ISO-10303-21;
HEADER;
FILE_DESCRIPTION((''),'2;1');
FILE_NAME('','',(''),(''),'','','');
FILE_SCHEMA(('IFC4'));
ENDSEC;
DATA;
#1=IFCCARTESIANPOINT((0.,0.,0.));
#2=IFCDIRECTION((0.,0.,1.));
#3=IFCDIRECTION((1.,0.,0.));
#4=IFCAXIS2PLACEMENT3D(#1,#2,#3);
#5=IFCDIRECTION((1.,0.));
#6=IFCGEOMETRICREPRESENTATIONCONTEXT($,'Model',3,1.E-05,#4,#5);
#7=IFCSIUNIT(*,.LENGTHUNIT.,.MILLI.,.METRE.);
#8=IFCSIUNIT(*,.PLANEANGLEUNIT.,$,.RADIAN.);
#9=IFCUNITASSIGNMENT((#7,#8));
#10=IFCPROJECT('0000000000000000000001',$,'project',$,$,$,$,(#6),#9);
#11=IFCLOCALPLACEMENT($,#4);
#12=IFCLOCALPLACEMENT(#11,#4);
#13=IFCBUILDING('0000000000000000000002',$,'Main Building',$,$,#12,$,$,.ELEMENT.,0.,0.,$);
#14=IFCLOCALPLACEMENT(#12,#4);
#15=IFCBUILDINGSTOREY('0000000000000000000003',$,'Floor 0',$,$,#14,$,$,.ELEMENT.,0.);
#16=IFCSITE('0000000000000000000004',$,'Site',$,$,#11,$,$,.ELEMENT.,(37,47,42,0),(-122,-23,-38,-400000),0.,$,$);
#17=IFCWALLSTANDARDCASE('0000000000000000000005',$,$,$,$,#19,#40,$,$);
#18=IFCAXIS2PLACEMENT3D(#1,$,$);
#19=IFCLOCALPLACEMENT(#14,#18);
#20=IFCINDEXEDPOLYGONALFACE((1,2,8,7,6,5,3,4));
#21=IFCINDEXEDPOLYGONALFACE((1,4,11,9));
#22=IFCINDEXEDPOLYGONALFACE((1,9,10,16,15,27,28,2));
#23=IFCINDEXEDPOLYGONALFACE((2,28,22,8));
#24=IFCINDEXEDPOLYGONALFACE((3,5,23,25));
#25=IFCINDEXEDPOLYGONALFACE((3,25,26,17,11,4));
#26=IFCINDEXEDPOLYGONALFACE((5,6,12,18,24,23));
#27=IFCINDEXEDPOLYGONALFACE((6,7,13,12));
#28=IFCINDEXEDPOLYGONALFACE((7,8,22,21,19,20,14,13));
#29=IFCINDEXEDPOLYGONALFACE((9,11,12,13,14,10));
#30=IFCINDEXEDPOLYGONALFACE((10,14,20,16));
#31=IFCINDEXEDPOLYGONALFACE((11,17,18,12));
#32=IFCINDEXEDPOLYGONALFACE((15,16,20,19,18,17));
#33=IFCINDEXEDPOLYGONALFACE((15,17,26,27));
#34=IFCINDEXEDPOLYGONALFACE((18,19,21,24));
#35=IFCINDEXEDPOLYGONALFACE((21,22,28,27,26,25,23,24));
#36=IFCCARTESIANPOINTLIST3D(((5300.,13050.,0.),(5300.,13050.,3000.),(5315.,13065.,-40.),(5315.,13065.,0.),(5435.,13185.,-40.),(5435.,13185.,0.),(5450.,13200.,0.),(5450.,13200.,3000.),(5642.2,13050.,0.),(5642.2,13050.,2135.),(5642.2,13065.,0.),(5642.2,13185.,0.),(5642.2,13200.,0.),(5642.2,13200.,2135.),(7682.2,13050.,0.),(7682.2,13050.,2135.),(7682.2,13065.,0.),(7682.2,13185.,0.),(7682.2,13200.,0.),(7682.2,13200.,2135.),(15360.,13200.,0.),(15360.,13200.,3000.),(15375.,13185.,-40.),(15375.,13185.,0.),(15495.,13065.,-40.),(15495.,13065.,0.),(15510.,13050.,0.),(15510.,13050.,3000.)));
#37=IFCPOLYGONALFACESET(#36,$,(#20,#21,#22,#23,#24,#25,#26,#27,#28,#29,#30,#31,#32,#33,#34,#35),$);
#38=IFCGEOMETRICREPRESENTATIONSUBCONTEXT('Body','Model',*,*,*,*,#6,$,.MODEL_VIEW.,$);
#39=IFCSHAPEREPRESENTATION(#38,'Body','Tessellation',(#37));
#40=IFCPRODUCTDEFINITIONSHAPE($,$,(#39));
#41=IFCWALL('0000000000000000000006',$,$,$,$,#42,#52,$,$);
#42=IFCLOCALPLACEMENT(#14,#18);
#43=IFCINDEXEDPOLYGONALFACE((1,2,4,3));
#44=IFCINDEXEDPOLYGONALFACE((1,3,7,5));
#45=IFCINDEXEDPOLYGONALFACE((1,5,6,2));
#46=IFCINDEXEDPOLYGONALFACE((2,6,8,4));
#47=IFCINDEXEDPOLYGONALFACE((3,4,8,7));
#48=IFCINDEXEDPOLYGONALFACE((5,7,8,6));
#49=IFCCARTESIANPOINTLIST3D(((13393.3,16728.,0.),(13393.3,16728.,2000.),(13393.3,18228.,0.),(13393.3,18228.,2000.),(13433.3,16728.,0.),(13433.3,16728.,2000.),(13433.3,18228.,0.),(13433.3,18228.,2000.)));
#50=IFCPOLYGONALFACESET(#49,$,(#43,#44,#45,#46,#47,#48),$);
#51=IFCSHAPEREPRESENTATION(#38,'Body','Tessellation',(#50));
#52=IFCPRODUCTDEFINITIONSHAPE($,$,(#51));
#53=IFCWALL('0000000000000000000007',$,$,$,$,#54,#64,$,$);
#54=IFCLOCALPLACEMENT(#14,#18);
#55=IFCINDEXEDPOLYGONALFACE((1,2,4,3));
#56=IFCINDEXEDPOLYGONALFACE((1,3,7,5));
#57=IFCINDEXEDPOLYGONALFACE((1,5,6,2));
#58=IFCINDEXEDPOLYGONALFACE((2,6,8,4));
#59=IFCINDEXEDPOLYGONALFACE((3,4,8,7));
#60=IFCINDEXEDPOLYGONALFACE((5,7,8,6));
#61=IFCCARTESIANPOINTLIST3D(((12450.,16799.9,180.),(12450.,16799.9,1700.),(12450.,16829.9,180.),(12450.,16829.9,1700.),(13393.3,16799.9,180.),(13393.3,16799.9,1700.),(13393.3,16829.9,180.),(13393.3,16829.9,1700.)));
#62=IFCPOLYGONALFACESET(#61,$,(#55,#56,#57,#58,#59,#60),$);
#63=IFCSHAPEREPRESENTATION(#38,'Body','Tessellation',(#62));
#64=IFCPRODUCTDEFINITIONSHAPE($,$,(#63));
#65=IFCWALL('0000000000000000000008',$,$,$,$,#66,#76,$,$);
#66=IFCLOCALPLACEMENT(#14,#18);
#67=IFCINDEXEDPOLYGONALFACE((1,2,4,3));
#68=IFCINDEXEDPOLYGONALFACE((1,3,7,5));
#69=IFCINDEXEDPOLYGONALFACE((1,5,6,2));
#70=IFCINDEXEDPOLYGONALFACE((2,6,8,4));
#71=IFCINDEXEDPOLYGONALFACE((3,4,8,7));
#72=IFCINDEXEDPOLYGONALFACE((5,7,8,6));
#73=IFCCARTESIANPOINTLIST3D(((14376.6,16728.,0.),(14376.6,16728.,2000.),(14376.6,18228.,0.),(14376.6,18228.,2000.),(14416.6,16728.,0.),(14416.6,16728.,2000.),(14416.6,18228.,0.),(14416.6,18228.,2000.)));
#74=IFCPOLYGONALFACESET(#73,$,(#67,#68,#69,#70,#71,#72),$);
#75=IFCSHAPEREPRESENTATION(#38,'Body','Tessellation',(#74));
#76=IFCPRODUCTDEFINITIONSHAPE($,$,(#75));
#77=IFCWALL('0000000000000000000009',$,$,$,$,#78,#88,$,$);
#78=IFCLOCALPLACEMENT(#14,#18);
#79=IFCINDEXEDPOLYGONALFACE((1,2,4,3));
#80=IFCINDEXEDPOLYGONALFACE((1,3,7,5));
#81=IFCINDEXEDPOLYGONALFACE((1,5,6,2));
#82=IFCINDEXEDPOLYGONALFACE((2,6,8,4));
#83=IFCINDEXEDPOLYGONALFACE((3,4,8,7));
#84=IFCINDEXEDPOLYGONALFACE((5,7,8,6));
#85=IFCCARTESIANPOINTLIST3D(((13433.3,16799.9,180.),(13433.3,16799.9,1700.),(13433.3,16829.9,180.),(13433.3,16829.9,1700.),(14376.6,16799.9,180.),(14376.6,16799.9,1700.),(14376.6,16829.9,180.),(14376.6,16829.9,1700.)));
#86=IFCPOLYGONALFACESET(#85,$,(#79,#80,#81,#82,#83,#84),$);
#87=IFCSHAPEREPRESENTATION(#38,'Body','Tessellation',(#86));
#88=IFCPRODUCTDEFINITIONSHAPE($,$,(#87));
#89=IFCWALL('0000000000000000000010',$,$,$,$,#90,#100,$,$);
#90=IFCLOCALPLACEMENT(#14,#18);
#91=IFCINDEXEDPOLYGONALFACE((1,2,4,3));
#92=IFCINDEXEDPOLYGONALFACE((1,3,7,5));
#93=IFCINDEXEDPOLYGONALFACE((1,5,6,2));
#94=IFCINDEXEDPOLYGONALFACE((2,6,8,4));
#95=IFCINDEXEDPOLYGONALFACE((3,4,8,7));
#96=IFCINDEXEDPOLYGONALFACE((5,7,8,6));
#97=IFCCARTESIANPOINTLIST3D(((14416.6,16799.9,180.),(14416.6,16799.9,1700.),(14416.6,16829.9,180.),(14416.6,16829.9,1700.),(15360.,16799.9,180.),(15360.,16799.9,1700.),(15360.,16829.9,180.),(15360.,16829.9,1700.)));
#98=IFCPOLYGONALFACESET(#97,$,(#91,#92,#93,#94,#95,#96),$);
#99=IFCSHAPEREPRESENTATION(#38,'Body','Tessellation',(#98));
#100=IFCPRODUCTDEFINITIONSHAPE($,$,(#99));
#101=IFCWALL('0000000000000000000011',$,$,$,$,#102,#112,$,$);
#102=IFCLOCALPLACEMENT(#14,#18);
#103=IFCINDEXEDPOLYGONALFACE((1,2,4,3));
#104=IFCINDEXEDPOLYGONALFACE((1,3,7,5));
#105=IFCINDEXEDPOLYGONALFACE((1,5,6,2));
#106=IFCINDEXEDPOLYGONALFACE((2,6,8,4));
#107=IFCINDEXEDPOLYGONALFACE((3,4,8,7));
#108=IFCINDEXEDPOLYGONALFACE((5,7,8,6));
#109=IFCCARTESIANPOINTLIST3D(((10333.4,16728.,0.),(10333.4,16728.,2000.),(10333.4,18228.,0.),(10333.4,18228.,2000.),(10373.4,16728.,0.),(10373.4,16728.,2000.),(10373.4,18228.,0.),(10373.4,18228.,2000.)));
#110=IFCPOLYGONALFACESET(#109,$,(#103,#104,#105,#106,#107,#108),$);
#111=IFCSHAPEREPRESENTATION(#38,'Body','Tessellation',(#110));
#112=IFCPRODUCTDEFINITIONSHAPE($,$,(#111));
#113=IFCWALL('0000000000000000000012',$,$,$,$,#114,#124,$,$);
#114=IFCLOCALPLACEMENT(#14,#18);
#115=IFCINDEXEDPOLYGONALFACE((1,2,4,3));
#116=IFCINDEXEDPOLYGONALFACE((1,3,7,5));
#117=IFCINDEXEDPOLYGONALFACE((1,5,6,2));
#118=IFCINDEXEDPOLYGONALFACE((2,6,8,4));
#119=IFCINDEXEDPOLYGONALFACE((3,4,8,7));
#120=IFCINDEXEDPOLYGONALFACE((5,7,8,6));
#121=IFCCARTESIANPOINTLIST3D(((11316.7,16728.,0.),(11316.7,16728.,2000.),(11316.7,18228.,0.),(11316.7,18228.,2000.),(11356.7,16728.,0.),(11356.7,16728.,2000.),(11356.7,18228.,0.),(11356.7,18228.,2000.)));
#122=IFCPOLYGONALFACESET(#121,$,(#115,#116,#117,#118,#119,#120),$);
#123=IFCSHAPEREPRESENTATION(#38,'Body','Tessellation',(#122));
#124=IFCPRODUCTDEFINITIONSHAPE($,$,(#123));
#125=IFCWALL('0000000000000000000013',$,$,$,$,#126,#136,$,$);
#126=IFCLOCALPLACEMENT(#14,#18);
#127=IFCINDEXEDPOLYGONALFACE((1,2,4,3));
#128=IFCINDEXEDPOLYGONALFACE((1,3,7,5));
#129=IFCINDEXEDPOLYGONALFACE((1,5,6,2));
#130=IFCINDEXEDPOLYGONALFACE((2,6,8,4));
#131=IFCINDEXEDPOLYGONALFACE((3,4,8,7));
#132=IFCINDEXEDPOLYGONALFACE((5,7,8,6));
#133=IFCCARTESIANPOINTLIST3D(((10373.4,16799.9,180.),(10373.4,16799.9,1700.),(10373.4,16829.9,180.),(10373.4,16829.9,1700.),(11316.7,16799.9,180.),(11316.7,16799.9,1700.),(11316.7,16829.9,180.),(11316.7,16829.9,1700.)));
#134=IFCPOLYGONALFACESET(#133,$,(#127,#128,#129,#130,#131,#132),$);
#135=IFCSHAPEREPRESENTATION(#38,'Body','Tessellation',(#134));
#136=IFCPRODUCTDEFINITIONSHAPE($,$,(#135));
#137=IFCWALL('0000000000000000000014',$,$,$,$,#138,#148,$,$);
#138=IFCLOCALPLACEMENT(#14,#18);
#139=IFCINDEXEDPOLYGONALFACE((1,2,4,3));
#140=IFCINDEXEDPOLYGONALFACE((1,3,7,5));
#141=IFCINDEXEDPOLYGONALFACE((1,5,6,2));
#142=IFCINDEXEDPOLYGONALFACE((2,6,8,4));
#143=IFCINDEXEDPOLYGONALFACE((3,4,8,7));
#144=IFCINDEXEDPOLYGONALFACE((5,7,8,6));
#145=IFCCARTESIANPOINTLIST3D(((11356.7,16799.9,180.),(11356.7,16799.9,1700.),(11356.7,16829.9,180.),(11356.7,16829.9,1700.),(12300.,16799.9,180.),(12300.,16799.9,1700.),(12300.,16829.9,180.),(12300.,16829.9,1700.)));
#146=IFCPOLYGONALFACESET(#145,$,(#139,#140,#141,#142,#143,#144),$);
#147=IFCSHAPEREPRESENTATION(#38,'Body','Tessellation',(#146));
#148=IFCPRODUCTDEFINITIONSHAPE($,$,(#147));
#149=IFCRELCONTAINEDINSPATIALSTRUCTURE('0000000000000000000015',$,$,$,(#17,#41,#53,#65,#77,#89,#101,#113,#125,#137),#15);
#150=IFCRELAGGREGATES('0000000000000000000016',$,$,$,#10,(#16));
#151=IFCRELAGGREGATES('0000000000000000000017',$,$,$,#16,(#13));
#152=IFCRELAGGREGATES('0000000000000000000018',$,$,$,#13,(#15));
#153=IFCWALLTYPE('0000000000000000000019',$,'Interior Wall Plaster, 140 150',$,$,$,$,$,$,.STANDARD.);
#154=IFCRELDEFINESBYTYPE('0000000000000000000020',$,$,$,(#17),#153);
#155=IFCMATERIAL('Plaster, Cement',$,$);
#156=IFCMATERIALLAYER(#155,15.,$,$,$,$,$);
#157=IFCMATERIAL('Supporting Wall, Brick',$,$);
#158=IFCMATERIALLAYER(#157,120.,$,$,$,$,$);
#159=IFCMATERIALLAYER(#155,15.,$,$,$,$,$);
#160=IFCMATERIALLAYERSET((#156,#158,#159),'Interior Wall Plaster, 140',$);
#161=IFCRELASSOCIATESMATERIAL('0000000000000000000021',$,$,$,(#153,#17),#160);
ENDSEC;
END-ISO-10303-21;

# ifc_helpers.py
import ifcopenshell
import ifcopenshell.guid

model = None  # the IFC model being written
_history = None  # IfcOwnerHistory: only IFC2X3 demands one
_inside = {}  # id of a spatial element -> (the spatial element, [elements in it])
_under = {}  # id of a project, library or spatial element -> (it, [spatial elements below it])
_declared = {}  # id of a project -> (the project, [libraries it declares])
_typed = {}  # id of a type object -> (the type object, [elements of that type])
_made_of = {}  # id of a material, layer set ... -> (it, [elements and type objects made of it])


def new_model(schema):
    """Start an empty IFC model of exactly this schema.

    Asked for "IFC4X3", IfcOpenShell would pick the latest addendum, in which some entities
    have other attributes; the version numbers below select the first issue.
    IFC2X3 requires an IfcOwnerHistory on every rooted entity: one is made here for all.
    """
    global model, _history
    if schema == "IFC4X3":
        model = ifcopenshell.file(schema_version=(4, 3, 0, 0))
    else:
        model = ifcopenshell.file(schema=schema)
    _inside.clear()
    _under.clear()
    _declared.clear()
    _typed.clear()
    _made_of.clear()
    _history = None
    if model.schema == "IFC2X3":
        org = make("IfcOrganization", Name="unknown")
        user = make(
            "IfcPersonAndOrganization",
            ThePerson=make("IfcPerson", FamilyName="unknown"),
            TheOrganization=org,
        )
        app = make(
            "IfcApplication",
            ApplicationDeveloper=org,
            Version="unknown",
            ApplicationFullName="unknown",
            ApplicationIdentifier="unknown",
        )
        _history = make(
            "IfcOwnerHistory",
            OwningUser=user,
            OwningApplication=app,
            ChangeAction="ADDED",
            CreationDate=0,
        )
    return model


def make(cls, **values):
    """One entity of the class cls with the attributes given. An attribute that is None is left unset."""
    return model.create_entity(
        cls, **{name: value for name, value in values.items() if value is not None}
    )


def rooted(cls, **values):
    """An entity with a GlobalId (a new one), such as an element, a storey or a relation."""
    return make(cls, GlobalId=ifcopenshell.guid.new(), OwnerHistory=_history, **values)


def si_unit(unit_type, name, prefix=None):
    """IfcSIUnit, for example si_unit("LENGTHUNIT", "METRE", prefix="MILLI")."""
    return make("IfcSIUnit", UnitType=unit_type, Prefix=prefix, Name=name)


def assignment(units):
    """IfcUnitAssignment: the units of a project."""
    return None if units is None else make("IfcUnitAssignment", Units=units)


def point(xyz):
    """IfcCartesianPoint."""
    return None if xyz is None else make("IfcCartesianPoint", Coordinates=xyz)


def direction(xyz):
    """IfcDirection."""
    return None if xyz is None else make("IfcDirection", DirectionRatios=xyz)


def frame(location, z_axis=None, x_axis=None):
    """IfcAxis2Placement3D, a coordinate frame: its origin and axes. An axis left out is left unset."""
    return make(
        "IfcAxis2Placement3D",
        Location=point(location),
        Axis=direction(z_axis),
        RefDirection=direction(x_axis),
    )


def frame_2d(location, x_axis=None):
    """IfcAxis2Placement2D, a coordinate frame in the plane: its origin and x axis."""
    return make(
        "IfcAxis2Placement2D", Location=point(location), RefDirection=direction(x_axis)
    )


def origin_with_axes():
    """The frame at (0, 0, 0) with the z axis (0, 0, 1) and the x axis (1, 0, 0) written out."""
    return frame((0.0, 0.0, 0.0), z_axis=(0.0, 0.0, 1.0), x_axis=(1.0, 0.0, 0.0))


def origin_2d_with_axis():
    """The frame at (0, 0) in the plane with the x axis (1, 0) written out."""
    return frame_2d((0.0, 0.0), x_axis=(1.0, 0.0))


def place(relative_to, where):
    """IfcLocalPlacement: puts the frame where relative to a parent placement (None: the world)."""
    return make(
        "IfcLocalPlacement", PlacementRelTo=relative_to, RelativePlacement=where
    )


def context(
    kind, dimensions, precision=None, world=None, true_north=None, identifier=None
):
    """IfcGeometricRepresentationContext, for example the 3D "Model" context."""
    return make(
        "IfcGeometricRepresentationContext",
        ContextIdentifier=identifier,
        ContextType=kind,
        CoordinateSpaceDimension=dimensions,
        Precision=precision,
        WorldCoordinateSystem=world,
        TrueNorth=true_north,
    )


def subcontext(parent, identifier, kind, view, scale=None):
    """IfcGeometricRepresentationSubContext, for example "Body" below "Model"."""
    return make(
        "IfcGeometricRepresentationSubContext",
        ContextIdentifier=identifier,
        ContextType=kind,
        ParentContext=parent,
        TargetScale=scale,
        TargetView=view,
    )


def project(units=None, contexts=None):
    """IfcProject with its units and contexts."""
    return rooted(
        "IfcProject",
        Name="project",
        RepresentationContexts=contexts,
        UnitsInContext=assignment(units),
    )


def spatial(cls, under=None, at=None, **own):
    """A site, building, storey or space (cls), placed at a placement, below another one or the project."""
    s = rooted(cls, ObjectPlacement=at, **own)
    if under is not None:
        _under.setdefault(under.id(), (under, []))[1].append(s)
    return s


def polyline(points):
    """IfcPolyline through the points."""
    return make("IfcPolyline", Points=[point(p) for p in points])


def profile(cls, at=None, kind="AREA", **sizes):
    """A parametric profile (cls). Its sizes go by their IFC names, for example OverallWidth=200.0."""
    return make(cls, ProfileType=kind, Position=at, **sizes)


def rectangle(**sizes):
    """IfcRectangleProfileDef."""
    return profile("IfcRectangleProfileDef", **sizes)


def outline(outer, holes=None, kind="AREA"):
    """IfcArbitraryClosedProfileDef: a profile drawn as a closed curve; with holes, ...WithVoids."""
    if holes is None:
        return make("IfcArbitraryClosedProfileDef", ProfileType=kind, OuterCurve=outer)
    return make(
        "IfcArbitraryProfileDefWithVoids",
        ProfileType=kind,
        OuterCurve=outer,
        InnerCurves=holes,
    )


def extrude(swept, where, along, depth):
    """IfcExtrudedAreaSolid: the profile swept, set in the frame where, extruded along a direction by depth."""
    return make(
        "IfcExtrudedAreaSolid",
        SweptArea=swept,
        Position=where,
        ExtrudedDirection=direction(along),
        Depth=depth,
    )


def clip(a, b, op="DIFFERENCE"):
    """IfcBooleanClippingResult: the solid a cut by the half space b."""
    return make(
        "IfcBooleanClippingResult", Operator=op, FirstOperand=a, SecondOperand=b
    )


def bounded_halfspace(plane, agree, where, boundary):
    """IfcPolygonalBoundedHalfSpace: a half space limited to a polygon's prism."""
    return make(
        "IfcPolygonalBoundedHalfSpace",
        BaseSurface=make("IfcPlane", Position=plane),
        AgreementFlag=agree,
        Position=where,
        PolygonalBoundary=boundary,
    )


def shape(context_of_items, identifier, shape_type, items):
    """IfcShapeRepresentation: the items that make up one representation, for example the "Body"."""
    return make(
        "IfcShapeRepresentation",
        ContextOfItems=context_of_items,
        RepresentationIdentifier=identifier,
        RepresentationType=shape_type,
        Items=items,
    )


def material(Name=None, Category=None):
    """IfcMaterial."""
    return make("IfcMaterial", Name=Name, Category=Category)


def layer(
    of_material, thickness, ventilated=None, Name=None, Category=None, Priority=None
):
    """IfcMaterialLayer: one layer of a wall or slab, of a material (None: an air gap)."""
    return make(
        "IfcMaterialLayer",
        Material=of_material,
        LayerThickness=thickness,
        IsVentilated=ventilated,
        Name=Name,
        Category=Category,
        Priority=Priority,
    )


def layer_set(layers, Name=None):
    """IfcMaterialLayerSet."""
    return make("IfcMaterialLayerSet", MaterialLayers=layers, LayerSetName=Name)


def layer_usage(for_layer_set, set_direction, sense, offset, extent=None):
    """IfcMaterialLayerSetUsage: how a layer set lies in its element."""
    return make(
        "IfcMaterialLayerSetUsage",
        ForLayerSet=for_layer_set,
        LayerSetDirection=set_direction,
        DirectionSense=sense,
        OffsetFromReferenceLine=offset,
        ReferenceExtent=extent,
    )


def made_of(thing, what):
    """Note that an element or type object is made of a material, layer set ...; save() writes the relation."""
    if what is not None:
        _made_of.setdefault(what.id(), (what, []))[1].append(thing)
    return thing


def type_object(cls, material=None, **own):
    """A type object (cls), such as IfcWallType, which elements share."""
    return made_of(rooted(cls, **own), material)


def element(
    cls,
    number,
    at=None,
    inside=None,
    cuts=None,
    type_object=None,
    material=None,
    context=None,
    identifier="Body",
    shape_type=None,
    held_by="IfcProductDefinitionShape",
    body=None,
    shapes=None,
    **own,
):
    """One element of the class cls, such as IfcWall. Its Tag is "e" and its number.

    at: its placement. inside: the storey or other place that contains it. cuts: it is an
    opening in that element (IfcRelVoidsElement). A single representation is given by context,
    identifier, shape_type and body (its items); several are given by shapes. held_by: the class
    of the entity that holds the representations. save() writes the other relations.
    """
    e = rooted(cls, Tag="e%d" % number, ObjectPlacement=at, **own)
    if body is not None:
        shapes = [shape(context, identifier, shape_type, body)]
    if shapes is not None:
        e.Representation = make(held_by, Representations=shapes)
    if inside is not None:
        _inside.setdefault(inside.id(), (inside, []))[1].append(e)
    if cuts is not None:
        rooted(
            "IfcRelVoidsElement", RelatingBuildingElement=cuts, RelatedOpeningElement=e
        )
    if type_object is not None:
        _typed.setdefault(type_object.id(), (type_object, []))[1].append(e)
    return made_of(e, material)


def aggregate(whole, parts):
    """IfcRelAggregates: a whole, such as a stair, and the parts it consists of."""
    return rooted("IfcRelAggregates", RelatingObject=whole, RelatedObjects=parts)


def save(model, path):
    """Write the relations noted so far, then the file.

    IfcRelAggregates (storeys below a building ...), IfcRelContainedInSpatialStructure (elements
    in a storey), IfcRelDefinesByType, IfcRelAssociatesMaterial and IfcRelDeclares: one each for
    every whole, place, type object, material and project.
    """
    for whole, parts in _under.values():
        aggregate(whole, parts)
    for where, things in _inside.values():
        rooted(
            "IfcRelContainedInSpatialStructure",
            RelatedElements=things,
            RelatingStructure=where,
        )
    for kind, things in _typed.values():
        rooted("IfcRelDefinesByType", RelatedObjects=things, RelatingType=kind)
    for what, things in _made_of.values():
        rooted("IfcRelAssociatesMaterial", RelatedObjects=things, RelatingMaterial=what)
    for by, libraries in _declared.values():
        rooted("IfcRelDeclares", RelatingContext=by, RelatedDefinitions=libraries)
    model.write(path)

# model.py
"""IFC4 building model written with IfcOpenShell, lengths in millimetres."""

from ifc_helpers import new_model, si_unit, direction, frame, frame_2d, origin_with_axes, origin_2d_with_axis, place, context, subcontext, project, spatial, polyline, rectangle, outline, extrude, clip, bounded_halfspace, material, layer, layer_set, layer_usage, type_object, element, save


model = new_model("IFC4")

# Units and contexts
model_context = context("Model", 3, precision=1e-05, world=origin_with_axes(), true_north=direction((1.0, 0.0)))
body_context = subcontext(model_context, "Body", "Model", "MODEL_VIEW")
ifc_project = project(units=[si_unit("LENGTHUNIT", "METRE", prefix="MILLI"), si_unit("PLANEANGLEUNIT", "RADIAN")], contexts=[model_context])

# Site, building, storey
site_placement = place(None, origin_with_axes())
site = spatial("IfcSite", under=ifc_project, at=site_placement, Name="Site", CompositionType="ELEMENT", RefLatitude=(37, 47, 42, 0), RefLongitude=(-122, -23, -38, -400000), RefElevation=0.0)
building_placement = place(site_placement, origin_with_axes())
building = spatial("IfcBuilding", under=site, at=building_placement, Name="Main Building", CompositionType="ELEMENT", ElevationOfRefHeight=0.0, ElevationOfTerrain=0.0)
storey_placement = place(building_placement, origin_with_axes())
storey = spatial("IfcBuildingStorey", under=building, at=storey_placement, Name="Floor 0", CompositionType="ELEMENT", Elevation=0.0)

# Shared definitions
ifc_material_1 = material(Name="Supporting Wall, Brick")

# Shared definitions
ifc_material_2 = material(Name="Plaster, Cement")
ifc_layer_1 = layer(ifc_material_2, 15.0)
ifc_layer_2 = layer(ifc_material_1, 120.0)
ifc_layer_3 = layer(ifc_material_2, 15.0)
ifc_layer_set_1 = layer_set([ifc_layer_1, ifc_layer_2, ifc_layer_3], Name="Interior Wall Plaster, 140")
wall_type_1 = type_object("IfcWallType", Name="Interior Wall Plaster, 140 150", PredefinedType="STANDARD", material=ifc_layer_set_1)

# Wall, opening
ifc_layer_usage_1 = layer_usage(ifc_layer_set_1, "AXIS2", "POSITIVE", 0.0)
wall_1_placement = place(storey_placement, frame((5300.0, 13050.0, -40.0), z_axis=(0.0, 0.0, 1.0), x_axis=(1.0, 0.0, 0.0)))
wall_1 = element("IfcWallStandardCase", 1, at=wall_1_placement, inside=storey, type_object=wall_type_1, material=ifc_layer_usage_1, context=body_context, shape_type="Clipping", body=[
    clip(clip(extrude(outline(polyline([(-4955.0, 75.0), (4955.0, 75.0), (5105.0, -75.0), (-5105.0, -75.0), (-4955.0, 75.0)])), frame((5105.0, 75.0, 0.0), z_axis=(0.0, 0.0, 1.0), x_axis=(1.0, 0.0, 0.0)), (0.0, 0.0, 1.0), 3040.0), bounded_halfspace(frame((-5300.0, -13050.0, 40.0), z_axis=(0.0, 0.0, -1.0), x_axis=(-1.0, 0.0, 0.0)), False, frame((5105.0, 75.0, 0.0), z_axis=(0.0, 0.0, 1.0), x_axis=(1.0, 0.0, 0.0)), polyline([(-4955.0, 75.0), (4955.0, 75.0), (4970.0, 60.0), (-4970.0, 60.0), (-4955.0, 75.0)]))), bounded_halfspace(frame((-5300.0, -13050.0, 40.0), z_axis=(0.0, 0.0, -1.0), x_axis=(-1.0, 0.0, 0.0)), False, frame((5105.0, 75.0, 0.0), z_axis=(0.0, 0.0, 1.0), x_axis=(1.0, 0.0, 0.0)), polyline([(-5090.0, -60.0), (5090.0, -60.0), (5105.0, -75.0), (-5105.0, -75.0), (-5090.0, -60.0)]))),
])
opening_1_placement = place(wall_1_placement, frame((2382.2, 150.0, 40.0), z_axis=(0.0, 0.0, 1.0), x_axis=(-1.0, 0.0, 0.0)))
element("IfcOpeningElement", 2, at=opening_1_placement, cuts=wall_1, ObjectType="Opening", context=body_context, shape_type="SweptSolid", body=[
    extrude(outline(polyline([(-1020.0, -1067.5), (-1020.0, 1067.5), (1020.0, 1067.5), (1020.0, -1067.5), (-1020.0, -1067.5)])), frame((1020.0, 0.0, 1067.5), z_axis=(0.0, 1.0, 0.0), x_axis=(1.0, 0.0, 0.0)), (0.0, 0.0, 1.0), 1000.0),
])

# Walls
wall_2_placement = place(storey_placement, origin_with_axes())
element("IfcWall", 3, at=wall_2_placement, inside=storey, context=body_context, shape_type="SweptSolid", body=[
    extrude(rectangle(XDim=1500.0, YDim=40.0, at=frame_2d((0.0, 0.0), x_axis=(0.0, 1.0))), frame((13413.3, 17478.0, 0.0), z_axis=(0.0, 0.0, 1.0), x_axis=(1.0, 0.0, 0.0)), (0.0, 0.0, 1.0), 2000.0),
])
wall_3_placement = place(storey_placement, origin_with_axes())
element("IfcWall", 4, at=wall_3_placement, inside=storey, context=body_context, shape_type="SweptSolid", body=[
    extrude(rectangle(XDim=943.3, YDim=30.0, at=origin_2d_with_axis()), frame((12921.7, 16814.9, 180.0), z_axis=(0.0, 0.0, 1.0), x_axis=(1.0, 0.0, 0.0)), (0.0, 0.0, 1.0), 1520.0),
])
wall_4_placement = place(storey_placement, origin_with_axes())
element("IfcWall", 5, at=wall_4_placement, inside=storey, context=body_context, shape_type="SweptSolid", body=[
    extrude(rectangle(XDim=1500.0, YDim=40.0, at=frame_2d((0.0, 0.0), x_axis=(0.0, 1.0))), frame((14396.6, 17478.0, 0.0), z_axis=(0.0, 0.0, 1.0), x_axis=(1.0, 0.0, 0.0)), (0.0, 0.0, 1.0), 2000.0),
])
wall_5_placement = place(storey_placement, origin_with_axes())
element("IfcWall", 6, at=wall_5_placement, inside=storey, context=body_context, shape_type="SweptSolid", body=[
    extrude(rectangle(XDim=943.3, YDim=30.0, at=origin_2d_with_axis()), frame((13905.0, 16814.9, 180.0), z_axis=(0.0, 0.0, 1.0), x_axis=(1.0, 0.0, 0.0)), (0.0, 0.0, 1.0), 1520.0),
])
wall_6_placement = place(storey_placement, origin_with_axes())
element("IfcWall", 7, at=wall_6_placement, inside=storey, context=body_context, shape_type="SweptSolid", body=[
    extrude(rectangle(XDim=943.3, YDim=30.0, at=origin_2d_with_axis()), frame((14888.3, 16814.9, 180.0), z_axis=(0.0, 0.0, 1.0), x_axis=(1.0, 0.0, 0.0)), (0.0, 0.0, 1.0), 1520.0),
])
wall_7_placement = place(storey_placement, origin_with_axes())
element("IfcWall", 8, at=wall_7_placement, inside=storey, context=body_context, shape_type="SweptSolid", body=[
    extrude(rectangle(XDim=1500.0, YDim=40.0, at=frame_2d((0.0, 0.0), x_axis=(0.0, 1.0))), frame((10353.4, 17478.0, 0.0), z_axis=(0.0, 0.0, 1.0), x_axis=(1.0, 0.0, 0.0)), (0.0, 0.0, 1.0), 2000.0),
])
wall_8_placement = place(storey_placement, origin_with_axes())
element("IfcWall", 9, at=wall_8_placement, inside=storey, context=body_context, shape_type="SweptSolid", body=[
    extrude(rectangle(XDim=1500.0, YDim=40.0, at=frame_2d((0.0, 0.0), x_axis=(0.0, 1.0))), frame((11336.7, 17478.0, 0.0), z_axis=(0.0, 0.0, 1.0), x_axis=(1.0, 0.0, 0.0)), (0.0, 0.0, 1.0), 2000.0),
])
wall_9_placement = place(storey_placement, origin_with_axes())
element("IfcWall", 10, at=wall_9_placement, inside=storey, context=body_context, shape_type="SweptSolid", body=[
    extrude(rectangle(XDim=943.3, YDim=30.0, at=origin_2d_with_axis()), frame((10845.0, 16814.9, 180.0), z_axis=(0.0, 0.0, 1.0), x_axis=(1.0, 0.0, 0.0)), (0.0, 0.0, 1.0), 1520.0),
])
wall_10_placement = place(storey_placement, origin_with_axes())
element("IfcWall", 11, at=wall_10_placement, inside=storey, context=body_context, shape_type="SweptSolid", body=[
    extrude(rectangle(XDim=943.3, YDim=30.0, at=origin_2d_with_axis()), frame((11828.3, 16814.9, 180.0), z_axis=(0.0, 0.0, 1.0), x_axis=(1.0, 0.0, 0.0)), (0.0, 0.0, 1.0), 1520.0),
])

save(model, "model.ifc")
